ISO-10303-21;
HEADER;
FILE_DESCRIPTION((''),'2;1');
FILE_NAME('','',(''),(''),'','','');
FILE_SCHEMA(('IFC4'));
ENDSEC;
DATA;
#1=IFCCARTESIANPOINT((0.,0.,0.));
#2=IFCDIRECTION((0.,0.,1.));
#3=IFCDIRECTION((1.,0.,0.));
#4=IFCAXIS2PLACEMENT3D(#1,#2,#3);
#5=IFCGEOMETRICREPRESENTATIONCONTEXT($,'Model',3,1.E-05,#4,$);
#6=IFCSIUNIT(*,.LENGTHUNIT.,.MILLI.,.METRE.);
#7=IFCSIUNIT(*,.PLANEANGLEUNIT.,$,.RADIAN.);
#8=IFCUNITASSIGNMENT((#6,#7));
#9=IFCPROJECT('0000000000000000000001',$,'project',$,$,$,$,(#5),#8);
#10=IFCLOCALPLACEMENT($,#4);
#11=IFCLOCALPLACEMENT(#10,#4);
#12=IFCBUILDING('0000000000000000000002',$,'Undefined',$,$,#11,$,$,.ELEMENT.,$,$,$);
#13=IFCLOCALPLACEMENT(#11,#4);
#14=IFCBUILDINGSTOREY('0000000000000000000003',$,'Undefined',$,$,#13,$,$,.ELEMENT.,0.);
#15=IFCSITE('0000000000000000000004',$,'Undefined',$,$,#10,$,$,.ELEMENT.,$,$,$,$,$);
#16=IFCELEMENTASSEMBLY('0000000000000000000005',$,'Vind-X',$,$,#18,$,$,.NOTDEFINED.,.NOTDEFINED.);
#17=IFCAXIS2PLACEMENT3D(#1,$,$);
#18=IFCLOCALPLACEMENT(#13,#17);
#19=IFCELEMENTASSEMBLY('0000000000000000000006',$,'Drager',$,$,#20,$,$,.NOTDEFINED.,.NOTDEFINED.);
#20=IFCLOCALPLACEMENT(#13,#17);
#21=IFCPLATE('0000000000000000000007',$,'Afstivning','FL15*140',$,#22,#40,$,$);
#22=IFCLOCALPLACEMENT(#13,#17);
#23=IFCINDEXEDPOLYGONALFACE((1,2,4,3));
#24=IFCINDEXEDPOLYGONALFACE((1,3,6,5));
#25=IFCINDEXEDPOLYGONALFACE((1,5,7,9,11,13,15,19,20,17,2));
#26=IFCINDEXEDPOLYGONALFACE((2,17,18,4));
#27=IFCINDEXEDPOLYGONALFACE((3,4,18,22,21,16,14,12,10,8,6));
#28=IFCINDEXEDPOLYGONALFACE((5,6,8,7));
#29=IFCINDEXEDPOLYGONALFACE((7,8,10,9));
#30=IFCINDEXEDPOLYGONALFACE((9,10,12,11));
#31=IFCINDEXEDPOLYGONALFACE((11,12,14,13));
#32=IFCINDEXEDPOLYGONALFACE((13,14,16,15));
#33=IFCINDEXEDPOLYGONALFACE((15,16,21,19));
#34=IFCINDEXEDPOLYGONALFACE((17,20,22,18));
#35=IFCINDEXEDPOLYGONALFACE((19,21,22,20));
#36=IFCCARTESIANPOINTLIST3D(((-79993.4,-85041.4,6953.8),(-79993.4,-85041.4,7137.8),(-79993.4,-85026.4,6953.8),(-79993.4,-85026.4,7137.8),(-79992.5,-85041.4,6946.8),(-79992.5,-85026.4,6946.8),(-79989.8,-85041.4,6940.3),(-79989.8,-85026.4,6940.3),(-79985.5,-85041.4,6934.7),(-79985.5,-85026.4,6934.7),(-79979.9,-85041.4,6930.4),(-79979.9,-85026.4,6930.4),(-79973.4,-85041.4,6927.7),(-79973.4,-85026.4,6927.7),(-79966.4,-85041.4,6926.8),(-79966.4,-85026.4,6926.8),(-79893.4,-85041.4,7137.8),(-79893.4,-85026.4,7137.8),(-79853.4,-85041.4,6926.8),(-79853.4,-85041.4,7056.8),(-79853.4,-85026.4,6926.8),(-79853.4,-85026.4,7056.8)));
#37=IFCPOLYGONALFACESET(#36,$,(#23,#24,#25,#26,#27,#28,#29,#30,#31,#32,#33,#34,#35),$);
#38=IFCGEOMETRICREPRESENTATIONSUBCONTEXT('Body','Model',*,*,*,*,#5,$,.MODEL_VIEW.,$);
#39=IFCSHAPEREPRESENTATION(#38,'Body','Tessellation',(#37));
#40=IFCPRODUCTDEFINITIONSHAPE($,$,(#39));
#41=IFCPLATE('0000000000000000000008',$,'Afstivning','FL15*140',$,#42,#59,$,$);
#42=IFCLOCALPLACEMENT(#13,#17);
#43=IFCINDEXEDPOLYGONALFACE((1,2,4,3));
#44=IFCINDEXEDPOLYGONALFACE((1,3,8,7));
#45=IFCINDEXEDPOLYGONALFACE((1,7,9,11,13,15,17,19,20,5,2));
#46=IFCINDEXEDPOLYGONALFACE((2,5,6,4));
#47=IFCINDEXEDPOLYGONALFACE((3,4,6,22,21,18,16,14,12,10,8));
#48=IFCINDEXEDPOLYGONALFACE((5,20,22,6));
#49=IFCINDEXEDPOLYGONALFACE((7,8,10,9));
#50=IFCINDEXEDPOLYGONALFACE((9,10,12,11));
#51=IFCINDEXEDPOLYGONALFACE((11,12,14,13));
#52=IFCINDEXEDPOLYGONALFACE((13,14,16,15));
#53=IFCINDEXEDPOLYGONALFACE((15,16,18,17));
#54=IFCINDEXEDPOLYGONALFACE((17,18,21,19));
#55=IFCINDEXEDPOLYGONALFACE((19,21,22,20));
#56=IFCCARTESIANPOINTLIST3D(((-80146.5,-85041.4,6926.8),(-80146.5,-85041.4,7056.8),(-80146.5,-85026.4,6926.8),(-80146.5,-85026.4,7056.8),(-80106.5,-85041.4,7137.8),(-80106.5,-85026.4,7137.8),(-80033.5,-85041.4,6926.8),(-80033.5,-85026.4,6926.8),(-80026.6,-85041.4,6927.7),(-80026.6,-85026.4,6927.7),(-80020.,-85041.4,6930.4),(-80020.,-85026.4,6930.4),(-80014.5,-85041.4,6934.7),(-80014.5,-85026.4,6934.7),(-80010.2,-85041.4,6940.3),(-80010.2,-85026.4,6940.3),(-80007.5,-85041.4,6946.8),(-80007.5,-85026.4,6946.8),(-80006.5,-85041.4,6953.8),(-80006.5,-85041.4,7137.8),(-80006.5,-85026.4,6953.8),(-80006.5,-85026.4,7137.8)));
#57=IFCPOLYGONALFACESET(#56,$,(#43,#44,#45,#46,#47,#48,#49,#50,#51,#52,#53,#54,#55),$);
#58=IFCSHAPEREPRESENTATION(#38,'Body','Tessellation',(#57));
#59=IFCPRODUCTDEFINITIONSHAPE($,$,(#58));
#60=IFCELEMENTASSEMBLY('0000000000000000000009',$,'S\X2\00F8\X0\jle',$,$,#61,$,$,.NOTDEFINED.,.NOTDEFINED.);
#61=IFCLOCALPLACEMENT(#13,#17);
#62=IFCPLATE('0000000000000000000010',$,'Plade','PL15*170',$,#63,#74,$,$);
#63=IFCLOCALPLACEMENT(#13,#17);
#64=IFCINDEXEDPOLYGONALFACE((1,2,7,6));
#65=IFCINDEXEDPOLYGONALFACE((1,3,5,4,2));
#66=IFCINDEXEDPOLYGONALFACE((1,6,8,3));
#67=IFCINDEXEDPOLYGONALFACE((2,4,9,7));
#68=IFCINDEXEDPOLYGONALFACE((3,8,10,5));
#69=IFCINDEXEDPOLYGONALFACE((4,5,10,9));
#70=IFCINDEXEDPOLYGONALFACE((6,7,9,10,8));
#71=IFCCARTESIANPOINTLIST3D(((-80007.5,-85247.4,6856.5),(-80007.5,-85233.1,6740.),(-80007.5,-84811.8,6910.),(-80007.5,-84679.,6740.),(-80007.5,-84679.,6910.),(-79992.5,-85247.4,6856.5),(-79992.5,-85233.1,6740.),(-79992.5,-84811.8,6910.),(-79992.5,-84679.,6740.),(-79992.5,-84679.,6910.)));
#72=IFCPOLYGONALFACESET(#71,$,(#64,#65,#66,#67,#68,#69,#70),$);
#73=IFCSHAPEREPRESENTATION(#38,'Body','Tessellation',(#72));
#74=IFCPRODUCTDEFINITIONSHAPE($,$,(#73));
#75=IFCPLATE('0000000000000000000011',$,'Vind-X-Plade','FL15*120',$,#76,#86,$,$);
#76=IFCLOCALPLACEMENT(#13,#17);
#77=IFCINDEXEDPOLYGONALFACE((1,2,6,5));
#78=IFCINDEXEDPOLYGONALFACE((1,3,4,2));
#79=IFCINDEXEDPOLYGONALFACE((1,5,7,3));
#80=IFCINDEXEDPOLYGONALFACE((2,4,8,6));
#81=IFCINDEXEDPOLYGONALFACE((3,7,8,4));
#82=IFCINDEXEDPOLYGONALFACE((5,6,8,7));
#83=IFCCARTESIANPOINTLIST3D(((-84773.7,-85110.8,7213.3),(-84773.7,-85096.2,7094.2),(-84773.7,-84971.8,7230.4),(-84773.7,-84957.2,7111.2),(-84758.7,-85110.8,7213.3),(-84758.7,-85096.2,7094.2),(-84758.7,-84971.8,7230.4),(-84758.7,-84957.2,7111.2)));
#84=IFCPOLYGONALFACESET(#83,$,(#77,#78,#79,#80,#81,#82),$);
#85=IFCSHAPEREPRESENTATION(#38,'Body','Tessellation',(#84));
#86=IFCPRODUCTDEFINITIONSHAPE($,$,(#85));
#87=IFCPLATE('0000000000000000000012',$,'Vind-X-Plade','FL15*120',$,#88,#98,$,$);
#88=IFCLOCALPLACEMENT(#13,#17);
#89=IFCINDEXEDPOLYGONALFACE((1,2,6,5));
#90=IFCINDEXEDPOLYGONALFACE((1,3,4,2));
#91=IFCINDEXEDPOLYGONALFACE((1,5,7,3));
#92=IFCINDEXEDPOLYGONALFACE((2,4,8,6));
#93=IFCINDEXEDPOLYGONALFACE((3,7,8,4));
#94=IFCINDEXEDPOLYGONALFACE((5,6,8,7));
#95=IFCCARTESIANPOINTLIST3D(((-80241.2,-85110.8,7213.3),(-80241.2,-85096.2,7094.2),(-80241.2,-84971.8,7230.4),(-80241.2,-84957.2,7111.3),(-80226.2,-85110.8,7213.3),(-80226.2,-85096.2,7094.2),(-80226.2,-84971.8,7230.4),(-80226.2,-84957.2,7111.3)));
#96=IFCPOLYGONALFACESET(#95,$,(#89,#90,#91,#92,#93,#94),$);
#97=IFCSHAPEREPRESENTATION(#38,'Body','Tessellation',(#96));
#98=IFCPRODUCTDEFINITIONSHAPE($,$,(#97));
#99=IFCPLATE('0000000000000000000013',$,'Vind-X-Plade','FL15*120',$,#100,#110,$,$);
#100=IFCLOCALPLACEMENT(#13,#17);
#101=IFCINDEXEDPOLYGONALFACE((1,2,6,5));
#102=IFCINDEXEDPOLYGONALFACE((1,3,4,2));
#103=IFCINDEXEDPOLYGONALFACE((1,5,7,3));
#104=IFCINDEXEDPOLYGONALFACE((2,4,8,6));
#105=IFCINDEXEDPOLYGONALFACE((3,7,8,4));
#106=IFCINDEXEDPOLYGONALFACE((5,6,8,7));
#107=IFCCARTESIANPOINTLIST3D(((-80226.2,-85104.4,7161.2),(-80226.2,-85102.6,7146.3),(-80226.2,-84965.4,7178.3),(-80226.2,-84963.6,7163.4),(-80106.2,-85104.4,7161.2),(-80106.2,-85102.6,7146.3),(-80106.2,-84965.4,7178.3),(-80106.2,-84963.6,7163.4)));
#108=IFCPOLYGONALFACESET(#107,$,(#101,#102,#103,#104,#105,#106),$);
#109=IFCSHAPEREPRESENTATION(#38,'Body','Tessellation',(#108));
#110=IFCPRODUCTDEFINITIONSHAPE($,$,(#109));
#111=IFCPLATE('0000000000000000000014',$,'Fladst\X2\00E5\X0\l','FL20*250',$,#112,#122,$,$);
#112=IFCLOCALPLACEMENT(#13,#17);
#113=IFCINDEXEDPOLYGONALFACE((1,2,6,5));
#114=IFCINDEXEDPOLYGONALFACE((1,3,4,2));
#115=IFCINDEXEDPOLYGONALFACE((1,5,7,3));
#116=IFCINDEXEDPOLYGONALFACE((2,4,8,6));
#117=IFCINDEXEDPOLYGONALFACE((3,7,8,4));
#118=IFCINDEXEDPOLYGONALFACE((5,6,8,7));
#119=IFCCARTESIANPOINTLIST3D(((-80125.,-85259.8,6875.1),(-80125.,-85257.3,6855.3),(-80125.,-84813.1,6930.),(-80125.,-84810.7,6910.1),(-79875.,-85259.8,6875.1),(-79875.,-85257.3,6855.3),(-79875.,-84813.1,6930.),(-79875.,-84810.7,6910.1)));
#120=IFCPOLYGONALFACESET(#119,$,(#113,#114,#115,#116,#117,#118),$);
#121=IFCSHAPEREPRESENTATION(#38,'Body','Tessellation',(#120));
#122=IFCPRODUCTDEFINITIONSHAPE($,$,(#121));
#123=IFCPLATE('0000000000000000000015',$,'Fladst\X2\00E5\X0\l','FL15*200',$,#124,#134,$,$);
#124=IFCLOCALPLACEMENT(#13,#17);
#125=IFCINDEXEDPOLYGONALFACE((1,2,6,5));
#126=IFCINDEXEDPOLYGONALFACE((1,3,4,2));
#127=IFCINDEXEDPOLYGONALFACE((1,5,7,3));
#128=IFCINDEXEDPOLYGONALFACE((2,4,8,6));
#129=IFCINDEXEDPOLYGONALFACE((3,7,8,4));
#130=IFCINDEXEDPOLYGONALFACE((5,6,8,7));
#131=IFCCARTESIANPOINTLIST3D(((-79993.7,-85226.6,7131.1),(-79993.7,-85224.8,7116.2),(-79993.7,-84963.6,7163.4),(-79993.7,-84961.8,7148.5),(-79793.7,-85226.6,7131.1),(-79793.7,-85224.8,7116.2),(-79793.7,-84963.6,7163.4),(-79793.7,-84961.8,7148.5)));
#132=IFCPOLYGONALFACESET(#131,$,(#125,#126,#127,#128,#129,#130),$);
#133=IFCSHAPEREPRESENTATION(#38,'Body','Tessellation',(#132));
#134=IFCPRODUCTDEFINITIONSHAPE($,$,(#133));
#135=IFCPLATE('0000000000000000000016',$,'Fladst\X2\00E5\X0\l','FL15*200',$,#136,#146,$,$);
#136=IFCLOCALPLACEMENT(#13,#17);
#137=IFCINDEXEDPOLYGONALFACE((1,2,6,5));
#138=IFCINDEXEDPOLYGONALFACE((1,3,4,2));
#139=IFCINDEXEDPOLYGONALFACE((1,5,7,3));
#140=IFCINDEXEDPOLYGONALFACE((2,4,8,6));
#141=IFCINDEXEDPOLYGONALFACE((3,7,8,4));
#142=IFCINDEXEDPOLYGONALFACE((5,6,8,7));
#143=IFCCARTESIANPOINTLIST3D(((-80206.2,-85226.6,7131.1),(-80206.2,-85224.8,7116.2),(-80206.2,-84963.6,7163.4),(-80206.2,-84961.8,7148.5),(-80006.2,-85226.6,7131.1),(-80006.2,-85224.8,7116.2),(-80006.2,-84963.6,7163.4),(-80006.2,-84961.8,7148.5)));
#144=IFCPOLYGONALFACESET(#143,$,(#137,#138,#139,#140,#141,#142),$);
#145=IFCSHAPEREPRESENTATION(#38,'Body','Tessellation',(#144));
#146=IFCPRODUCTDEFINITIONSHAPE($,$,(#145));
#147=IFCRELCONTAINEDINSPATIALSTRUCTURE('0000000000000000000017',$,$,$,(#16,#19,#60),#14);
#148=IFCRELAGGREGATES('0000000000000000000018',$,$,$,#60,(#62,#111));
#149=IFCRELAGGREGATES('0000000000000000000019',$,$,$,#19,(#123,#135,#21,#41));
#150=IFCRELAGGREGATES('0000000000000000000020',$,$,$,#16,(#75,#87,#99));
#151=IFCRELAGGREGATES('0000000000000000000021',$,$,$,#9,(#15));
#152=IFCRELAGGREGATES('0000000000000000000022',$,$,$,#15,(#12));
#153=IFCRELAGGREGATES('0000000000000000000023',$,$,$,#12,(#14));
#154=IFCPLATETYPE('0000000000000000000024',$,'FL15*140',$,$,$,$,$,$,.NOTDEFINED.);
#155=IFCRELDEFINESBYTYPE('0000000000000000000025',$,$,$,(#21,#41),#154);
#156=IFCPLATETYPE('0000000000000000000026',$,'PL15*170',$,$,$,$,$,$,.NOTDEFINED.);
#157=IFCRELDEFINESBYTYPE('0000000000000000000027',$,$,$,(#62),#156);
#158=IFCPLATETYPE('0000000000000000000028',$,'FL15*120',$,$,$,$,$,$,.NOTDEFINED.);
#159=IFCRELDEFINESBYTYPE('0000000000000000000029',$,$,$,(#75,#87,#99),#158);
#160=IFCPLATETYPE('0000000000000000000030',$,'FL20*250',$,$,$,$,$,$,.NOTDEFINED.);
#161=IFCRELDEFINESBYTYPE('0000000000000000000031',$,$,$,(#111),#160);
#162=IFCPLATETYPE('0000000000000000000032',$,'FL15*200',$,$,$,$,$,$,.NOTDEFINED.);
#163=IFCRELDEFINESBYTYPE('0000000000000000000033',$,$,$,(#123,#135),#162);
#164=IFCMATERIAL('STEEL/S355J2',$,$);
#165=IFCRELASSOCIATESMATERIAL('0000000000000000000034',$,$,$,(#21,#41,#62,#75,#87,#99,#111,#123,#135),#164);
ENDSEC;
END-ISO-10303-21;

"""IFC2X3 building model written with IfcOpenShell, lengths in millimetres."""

from ifc_helpers import new_model, si_unit, frame, frame_2d, origin_with_axes, place, context, subcontext, project, spatial, polyline, circle_curve, parameter, trimmed, segment, composite_curve, outline, extrude, material, type_object, element, aggregate, save


model = new_model("IFC2X3")

# Units and contexts
model_context = context("Model", 3, precision=1e-05, world=origin_with_axes())
body_context = subcontext(model_context, "Body", "Model", "MODEL_VIEW")
ifc_project = project(units=[si_unit("LENGTHUNIT", "METRE", prefix="MILLI"), si_unit("PLANEANGLEUNIT", "RADIAN")], contexts=[model_context])

# Site, building, storey
site_placement = place(None, origin_with_axes())
site = spatial("IfcSite", under=ifc_project, at=site_placement, Name="Undefined", CompositionType="ELEMENT")
building_placement = place(site_placement, origin_with_axes())
building = spatial("IfcBuilding", under=site, at=building_placement, Name="Undefined", CompositionType="ELEMENT")
storey_placement = place(building_placement, origin_with_axes())
storey = spatial("IfcBuildingStorey", under=building, at=storey_placement, Name="Undefined", CompositionType="ELEMENT", Elevation=0.0)

# Shared definitions
ifc_material_1 = material(Name="STEEL/S355J2")

# Element assembly
assembly_1_placement = place(storey_placement, origin_with_axes())
assembly_1 = element("IfcElementAssembly", 1, at=assembly_1_placement, inside=storey, Name="Vind-X", AssemblyPlace="NOTDEFINED", PredefinedType="NOTDEFINED")

# Element assembly, plates
assembly_2_placement = place(storey_placement, origin_with_axes())
assembly_2 = element("IfcElementAssembly", 2, at=assembly_2_placement, inside=storey, Name="Drager", AssemblyPlace="NOTDEFINED", PredefinedType="NOTDEFINED")
plate_type_1 = type_object("IfcPlateType", Name="FL15*140", PredefinedType="NOTDEFINED")
plate_1_placement = place(assembly_2_placement, frame((-79993.4, -85033.9, 6926.8), z_axis=(0.0, -1.0, 0.0), x_axis=(1.0, 0.0, 0.0)))
plate_1 = element("IfcPlate", 3, at=plate_1_placement, type_object=plate_type_1, material=ifc_material_1, Name="Afstivning", Description="FL15*140", context=body_context, shape_type="SweptSolid", body=[
    extrude(outline(composite_curve([segment(trimmed(circle_curve(frame_2d((27.0, 27.0), x_axis=(-1.0, 0.0)), 27.0), [parameter(0.0)], [parameter(1.570796)], True, "PARAMETER"), True, "CONTINUOUS"), segment(polyline([(27.0, 0.0), (140.0, 0.0), (140.0, 130.0), (100.0, 211.0), (0.0, 211.0), (0.0, 27.0)]), True, "CONTINUOUS")], self_intersect=True)), frame((0.0, 0.0, -7.5), z_axis=(0.0, 0.0, 1.0), x_axis=(1.0, 0.0, 0.0)), (0.0, 0.0, 1.0), 15.0),
])
plate_2_placement = place(assembly_2_placement, frame((-80146.5, -85033.9, 6926.8), z_axis=(0.0, -1.0, 0.0), x_axis=(1.0, 0.0, 0.0)))
plate_2 = element("IfcPlate", 4, at=plate_2_placement, type_object=plate_type_1, material=ifc_material_1, Name="Afstivning", Description="FL15*140", context=body_context, shape_type="SweptSolid", body=[
    extrude(outline(composite_curve([segment(polyline([(0.0, 0.0), (113.0, 0.0)]), True, "CONTINUOUS"), segment(trimmed(circle_curve(frame_2d((113.0, 27.0), x_axis=(0.0, -1.0)), 27.0), [parameter(0.0)], [parameter(1.570796)], True, "PARAMETER"), True, "CONTINUOUS"), segment(polyline([(140.0, 27.0), (140.0, 211.0), (40.0, 211.0), (0.0, 130.0), (0.0, 0.0)]), True, "CONTINUOUS")], self_intersect=True)), frame((0.0, 0.0, -7.5), z_axis=(0.0, 0.0, 1.0), x_axis=(1.0, 0.0, 0.0)), (0.0, 0.0, 1.0), 15.0),
])

# Element assembly, plate
assembly_3_placement = place(storey_placement, origin_with_axes())
assembly_3 = element("IfcElementAssembly", 5, at=assembly_3_placement, inside=storey, Name="Søjle", AssemblyPlace="NOTDEFINED", PredefinedType="NOTDEFINED")
plate_type_2 = type_object("IfcPlateType", Name="PL15*170", PredefinedType="NOTDEFINED")
plate_3_placement = place(assembly_3_placement, frame((-80000.0, -85247.4, 6856.5), z_axis=(1.0, 0.0, 0.0), x_axis=(0.0, 0.121869, -0.992546)))
plate_3 = element("IfcPlate", 6, at=plate_3_placement, type_object=plate_type_2, material=ifc_material_1, Name="Plade", Description="PL15*170", context=body_context, shape_type="SweptSolid", body=[
    extrude(outline(polyline([(0.0, 0.0), (117.4, 0.0), (184.9, 550.0), (16.2, 570.7), (0.0, 438.9), (0.0, 0.0)])), frame((0.0, 0.0, -7.5), z_axis=(0.0, 0.0, 1.0), x_axis=(1.0, 0.0, 0.0)), (0.0, 0.0, 1.0), 15.0),
])

# Plates
plate_type_3 = type_object("IfcPlateType", Name="FL15*120", PredefinedType="NOTDEFINED")
plate_4_placement = place(assembly_1_placement, frame((-84766.2, -84957.2, 7111.2), z_axis=(-1.0, 0.0, -0.000007), x_axis=(0.0, -0.992546, -0.121869)))
plate_4 = element("IfcPlate", 7, at=plate_4_placement, type_object=plate_type_3, material=ifc_material_1, Name="Vind-X-Plade", Description="FL15*120", context=body_context, shape_type="SweptSolid", body=[
    extrude(outline(polyline([(0.0, 0.0), (140.0, 0.0), (140.0, 120.0), (0.0, 120.0), (0.0, 0.0)])), frame((0.0, 0.0, -7.5), z_axis=(0.0, 0.0, 1.0), x_axis=(1.0, 0.0, 0.0)), (0.0, 0.0, 1.0), 15.0),
])
plate_5_placement = place(assembly_1_placement, frame((-80233.7, -85096.2, 7094.2), z_axis=(1.0, 0.0, 0.000007), x_axis=(0.0, 0.992546, 0.121869)))
plate_5 = element("IfcPlate", 8, at=plate_5_placement, type_object=plate_type_3, material=ifc_material_1, Name="Vind-X-Plade", Description="FL15*120", context=body_context, shape_type="SweptSolid", body=[
    extrude(outline(polyline([(0.0, 0.0), (140.0, 0.0), (140.0, 120.0), (0.0, 120.0), (0.0, 0.0)])), frame((0.0, 0.0, -7.5), z_axis=(0.0, 0.0, 1.0), x_axis=(1.0, 0.0, 0.0)), (0.0, 0.0, 1.0), 15.0),
])
plate_6_placement = place(assembly_1_placement, frame((-80106.2, -85034.0, 7162.3), z_axis=(0.000007, 0.121869, -0.992546), x_axis=(-1.0, 0.0, -0.000007)))
plate_6 = element("IfcPlate", 9, at=plate_6_placement, type_object=plate_type_3, material=ifc_material_1, Name="Vind-X-Plade", Description="FL15*120", context=body_context, shape_type="SweptSolid", body=[
    extrude(outline(polyline([(0.0, -70.0), (0.0, 70.0), (120.0, 70.0), (120.0, -70.0), (0.0, -70.0)])), frame((0.0, 0.0, -7.5), z_axis=(0.0, 0.0, 1.0), x_axis=(1.0, 0.0, 0.0)), (0.0, 0.0, 1.0), 15.0),
])
plate_type_4 = type_object("IfcPlateType", Name="FL20*250", PredefinedType="NOTDEFINED")
plate_7_placement = place(assembly_3_placement, frame((-80000.0, -85258.5, 6865.2), z_axis=(0.0, 0.121869, -0.992546), x_axis=(0.0, 0.992546, 0.121869)))
plate_7 = element("IfcPlate", 10, at=plate_7_placement, type_object=plate_type_4, material=ifc_material_1, Name="Fladstål", Description="FL20*250", context=body_context, shape_type="SweptSolid", body=[
    extrude(outline(polyline([(0.0, -125.0), (0.0, 125.0), (450.0, 125.0), (450.0, -125.0), (0.0, -125.0)])), frame((0.0, 0.0, -10.0), z_axis=(0.0, 0.0, 1.0), x_axis=(1.0, 0.0, 0.0)), (0.0, 0.0, 1.0), 20.0),
])
plate_type_5 = type_object("IfcPlateType", Name="FL15*200", PredefinedType="NOTDEFINED")
plate_8_placement = place(assembly_2_placement, frame((-79993.7, -84962.7, 7155.9), z_axis=(0.0, -0.121869, 0.992546), x_axis=(0.0, -0.992546, -0.121869)))
plate_8 = element("IfcPlate", 11, at=plate_8_placement, type_object=plate_type_5, material=ifc_material_1, Name="Fladstål", Description="FL15*200", context=body_context, shape_type="SweptSolid", body=[
    extrude(outline(polyline([(0.0, 0.0), (265.0, 0.0), (265.0, 200.0), (0.0, 200.0), (0.0, 0.0)])), frame((0.0, 0.0, -7.5), z_axis=(0.0, 0.0, 1.0), x_axis=(1.0, 0.0, 0.0)), (0.0, 0.0, 1.0), 15.0),
])
plate_9_placement = place(assembly_2_placement, frame((-80006.2, -85225.7, 7123.6), z_axis=(0.0, -0.121869, 0.992546), x_axis=(0.0, 0.992546, 0.121869)))
plate_9 = element("IfcPlate", 12, at=plate_9_placement, type_object=plate_type_5, material=ifc_material_1, Name="Fladstål", Description="FL15*200", context=body_context, shape_type="SweptSolid", body=[
    extrude(outline(polyline([(0.0, 0.0), (265.0, 0.0), (265.0, 200.0), (0.0, 200.0), (0.0, 0.0)])), frame((0.0, 0.0, -7.5), z_axis=(0.0, 0.0, 1.0), x_axis=(1.0, 0.0, 0.0)), (0.0, 0.0, 1.0), 15.0),
])

aggregate(assembly_3, [plate_3, plate_7])
aggregate(assembly_2, [plate_8, plate_9, plate_1, plate_2])
aggregate(assembly_1, [plate_4, plate_5, plate_6])

save(model, "model.ifc")
